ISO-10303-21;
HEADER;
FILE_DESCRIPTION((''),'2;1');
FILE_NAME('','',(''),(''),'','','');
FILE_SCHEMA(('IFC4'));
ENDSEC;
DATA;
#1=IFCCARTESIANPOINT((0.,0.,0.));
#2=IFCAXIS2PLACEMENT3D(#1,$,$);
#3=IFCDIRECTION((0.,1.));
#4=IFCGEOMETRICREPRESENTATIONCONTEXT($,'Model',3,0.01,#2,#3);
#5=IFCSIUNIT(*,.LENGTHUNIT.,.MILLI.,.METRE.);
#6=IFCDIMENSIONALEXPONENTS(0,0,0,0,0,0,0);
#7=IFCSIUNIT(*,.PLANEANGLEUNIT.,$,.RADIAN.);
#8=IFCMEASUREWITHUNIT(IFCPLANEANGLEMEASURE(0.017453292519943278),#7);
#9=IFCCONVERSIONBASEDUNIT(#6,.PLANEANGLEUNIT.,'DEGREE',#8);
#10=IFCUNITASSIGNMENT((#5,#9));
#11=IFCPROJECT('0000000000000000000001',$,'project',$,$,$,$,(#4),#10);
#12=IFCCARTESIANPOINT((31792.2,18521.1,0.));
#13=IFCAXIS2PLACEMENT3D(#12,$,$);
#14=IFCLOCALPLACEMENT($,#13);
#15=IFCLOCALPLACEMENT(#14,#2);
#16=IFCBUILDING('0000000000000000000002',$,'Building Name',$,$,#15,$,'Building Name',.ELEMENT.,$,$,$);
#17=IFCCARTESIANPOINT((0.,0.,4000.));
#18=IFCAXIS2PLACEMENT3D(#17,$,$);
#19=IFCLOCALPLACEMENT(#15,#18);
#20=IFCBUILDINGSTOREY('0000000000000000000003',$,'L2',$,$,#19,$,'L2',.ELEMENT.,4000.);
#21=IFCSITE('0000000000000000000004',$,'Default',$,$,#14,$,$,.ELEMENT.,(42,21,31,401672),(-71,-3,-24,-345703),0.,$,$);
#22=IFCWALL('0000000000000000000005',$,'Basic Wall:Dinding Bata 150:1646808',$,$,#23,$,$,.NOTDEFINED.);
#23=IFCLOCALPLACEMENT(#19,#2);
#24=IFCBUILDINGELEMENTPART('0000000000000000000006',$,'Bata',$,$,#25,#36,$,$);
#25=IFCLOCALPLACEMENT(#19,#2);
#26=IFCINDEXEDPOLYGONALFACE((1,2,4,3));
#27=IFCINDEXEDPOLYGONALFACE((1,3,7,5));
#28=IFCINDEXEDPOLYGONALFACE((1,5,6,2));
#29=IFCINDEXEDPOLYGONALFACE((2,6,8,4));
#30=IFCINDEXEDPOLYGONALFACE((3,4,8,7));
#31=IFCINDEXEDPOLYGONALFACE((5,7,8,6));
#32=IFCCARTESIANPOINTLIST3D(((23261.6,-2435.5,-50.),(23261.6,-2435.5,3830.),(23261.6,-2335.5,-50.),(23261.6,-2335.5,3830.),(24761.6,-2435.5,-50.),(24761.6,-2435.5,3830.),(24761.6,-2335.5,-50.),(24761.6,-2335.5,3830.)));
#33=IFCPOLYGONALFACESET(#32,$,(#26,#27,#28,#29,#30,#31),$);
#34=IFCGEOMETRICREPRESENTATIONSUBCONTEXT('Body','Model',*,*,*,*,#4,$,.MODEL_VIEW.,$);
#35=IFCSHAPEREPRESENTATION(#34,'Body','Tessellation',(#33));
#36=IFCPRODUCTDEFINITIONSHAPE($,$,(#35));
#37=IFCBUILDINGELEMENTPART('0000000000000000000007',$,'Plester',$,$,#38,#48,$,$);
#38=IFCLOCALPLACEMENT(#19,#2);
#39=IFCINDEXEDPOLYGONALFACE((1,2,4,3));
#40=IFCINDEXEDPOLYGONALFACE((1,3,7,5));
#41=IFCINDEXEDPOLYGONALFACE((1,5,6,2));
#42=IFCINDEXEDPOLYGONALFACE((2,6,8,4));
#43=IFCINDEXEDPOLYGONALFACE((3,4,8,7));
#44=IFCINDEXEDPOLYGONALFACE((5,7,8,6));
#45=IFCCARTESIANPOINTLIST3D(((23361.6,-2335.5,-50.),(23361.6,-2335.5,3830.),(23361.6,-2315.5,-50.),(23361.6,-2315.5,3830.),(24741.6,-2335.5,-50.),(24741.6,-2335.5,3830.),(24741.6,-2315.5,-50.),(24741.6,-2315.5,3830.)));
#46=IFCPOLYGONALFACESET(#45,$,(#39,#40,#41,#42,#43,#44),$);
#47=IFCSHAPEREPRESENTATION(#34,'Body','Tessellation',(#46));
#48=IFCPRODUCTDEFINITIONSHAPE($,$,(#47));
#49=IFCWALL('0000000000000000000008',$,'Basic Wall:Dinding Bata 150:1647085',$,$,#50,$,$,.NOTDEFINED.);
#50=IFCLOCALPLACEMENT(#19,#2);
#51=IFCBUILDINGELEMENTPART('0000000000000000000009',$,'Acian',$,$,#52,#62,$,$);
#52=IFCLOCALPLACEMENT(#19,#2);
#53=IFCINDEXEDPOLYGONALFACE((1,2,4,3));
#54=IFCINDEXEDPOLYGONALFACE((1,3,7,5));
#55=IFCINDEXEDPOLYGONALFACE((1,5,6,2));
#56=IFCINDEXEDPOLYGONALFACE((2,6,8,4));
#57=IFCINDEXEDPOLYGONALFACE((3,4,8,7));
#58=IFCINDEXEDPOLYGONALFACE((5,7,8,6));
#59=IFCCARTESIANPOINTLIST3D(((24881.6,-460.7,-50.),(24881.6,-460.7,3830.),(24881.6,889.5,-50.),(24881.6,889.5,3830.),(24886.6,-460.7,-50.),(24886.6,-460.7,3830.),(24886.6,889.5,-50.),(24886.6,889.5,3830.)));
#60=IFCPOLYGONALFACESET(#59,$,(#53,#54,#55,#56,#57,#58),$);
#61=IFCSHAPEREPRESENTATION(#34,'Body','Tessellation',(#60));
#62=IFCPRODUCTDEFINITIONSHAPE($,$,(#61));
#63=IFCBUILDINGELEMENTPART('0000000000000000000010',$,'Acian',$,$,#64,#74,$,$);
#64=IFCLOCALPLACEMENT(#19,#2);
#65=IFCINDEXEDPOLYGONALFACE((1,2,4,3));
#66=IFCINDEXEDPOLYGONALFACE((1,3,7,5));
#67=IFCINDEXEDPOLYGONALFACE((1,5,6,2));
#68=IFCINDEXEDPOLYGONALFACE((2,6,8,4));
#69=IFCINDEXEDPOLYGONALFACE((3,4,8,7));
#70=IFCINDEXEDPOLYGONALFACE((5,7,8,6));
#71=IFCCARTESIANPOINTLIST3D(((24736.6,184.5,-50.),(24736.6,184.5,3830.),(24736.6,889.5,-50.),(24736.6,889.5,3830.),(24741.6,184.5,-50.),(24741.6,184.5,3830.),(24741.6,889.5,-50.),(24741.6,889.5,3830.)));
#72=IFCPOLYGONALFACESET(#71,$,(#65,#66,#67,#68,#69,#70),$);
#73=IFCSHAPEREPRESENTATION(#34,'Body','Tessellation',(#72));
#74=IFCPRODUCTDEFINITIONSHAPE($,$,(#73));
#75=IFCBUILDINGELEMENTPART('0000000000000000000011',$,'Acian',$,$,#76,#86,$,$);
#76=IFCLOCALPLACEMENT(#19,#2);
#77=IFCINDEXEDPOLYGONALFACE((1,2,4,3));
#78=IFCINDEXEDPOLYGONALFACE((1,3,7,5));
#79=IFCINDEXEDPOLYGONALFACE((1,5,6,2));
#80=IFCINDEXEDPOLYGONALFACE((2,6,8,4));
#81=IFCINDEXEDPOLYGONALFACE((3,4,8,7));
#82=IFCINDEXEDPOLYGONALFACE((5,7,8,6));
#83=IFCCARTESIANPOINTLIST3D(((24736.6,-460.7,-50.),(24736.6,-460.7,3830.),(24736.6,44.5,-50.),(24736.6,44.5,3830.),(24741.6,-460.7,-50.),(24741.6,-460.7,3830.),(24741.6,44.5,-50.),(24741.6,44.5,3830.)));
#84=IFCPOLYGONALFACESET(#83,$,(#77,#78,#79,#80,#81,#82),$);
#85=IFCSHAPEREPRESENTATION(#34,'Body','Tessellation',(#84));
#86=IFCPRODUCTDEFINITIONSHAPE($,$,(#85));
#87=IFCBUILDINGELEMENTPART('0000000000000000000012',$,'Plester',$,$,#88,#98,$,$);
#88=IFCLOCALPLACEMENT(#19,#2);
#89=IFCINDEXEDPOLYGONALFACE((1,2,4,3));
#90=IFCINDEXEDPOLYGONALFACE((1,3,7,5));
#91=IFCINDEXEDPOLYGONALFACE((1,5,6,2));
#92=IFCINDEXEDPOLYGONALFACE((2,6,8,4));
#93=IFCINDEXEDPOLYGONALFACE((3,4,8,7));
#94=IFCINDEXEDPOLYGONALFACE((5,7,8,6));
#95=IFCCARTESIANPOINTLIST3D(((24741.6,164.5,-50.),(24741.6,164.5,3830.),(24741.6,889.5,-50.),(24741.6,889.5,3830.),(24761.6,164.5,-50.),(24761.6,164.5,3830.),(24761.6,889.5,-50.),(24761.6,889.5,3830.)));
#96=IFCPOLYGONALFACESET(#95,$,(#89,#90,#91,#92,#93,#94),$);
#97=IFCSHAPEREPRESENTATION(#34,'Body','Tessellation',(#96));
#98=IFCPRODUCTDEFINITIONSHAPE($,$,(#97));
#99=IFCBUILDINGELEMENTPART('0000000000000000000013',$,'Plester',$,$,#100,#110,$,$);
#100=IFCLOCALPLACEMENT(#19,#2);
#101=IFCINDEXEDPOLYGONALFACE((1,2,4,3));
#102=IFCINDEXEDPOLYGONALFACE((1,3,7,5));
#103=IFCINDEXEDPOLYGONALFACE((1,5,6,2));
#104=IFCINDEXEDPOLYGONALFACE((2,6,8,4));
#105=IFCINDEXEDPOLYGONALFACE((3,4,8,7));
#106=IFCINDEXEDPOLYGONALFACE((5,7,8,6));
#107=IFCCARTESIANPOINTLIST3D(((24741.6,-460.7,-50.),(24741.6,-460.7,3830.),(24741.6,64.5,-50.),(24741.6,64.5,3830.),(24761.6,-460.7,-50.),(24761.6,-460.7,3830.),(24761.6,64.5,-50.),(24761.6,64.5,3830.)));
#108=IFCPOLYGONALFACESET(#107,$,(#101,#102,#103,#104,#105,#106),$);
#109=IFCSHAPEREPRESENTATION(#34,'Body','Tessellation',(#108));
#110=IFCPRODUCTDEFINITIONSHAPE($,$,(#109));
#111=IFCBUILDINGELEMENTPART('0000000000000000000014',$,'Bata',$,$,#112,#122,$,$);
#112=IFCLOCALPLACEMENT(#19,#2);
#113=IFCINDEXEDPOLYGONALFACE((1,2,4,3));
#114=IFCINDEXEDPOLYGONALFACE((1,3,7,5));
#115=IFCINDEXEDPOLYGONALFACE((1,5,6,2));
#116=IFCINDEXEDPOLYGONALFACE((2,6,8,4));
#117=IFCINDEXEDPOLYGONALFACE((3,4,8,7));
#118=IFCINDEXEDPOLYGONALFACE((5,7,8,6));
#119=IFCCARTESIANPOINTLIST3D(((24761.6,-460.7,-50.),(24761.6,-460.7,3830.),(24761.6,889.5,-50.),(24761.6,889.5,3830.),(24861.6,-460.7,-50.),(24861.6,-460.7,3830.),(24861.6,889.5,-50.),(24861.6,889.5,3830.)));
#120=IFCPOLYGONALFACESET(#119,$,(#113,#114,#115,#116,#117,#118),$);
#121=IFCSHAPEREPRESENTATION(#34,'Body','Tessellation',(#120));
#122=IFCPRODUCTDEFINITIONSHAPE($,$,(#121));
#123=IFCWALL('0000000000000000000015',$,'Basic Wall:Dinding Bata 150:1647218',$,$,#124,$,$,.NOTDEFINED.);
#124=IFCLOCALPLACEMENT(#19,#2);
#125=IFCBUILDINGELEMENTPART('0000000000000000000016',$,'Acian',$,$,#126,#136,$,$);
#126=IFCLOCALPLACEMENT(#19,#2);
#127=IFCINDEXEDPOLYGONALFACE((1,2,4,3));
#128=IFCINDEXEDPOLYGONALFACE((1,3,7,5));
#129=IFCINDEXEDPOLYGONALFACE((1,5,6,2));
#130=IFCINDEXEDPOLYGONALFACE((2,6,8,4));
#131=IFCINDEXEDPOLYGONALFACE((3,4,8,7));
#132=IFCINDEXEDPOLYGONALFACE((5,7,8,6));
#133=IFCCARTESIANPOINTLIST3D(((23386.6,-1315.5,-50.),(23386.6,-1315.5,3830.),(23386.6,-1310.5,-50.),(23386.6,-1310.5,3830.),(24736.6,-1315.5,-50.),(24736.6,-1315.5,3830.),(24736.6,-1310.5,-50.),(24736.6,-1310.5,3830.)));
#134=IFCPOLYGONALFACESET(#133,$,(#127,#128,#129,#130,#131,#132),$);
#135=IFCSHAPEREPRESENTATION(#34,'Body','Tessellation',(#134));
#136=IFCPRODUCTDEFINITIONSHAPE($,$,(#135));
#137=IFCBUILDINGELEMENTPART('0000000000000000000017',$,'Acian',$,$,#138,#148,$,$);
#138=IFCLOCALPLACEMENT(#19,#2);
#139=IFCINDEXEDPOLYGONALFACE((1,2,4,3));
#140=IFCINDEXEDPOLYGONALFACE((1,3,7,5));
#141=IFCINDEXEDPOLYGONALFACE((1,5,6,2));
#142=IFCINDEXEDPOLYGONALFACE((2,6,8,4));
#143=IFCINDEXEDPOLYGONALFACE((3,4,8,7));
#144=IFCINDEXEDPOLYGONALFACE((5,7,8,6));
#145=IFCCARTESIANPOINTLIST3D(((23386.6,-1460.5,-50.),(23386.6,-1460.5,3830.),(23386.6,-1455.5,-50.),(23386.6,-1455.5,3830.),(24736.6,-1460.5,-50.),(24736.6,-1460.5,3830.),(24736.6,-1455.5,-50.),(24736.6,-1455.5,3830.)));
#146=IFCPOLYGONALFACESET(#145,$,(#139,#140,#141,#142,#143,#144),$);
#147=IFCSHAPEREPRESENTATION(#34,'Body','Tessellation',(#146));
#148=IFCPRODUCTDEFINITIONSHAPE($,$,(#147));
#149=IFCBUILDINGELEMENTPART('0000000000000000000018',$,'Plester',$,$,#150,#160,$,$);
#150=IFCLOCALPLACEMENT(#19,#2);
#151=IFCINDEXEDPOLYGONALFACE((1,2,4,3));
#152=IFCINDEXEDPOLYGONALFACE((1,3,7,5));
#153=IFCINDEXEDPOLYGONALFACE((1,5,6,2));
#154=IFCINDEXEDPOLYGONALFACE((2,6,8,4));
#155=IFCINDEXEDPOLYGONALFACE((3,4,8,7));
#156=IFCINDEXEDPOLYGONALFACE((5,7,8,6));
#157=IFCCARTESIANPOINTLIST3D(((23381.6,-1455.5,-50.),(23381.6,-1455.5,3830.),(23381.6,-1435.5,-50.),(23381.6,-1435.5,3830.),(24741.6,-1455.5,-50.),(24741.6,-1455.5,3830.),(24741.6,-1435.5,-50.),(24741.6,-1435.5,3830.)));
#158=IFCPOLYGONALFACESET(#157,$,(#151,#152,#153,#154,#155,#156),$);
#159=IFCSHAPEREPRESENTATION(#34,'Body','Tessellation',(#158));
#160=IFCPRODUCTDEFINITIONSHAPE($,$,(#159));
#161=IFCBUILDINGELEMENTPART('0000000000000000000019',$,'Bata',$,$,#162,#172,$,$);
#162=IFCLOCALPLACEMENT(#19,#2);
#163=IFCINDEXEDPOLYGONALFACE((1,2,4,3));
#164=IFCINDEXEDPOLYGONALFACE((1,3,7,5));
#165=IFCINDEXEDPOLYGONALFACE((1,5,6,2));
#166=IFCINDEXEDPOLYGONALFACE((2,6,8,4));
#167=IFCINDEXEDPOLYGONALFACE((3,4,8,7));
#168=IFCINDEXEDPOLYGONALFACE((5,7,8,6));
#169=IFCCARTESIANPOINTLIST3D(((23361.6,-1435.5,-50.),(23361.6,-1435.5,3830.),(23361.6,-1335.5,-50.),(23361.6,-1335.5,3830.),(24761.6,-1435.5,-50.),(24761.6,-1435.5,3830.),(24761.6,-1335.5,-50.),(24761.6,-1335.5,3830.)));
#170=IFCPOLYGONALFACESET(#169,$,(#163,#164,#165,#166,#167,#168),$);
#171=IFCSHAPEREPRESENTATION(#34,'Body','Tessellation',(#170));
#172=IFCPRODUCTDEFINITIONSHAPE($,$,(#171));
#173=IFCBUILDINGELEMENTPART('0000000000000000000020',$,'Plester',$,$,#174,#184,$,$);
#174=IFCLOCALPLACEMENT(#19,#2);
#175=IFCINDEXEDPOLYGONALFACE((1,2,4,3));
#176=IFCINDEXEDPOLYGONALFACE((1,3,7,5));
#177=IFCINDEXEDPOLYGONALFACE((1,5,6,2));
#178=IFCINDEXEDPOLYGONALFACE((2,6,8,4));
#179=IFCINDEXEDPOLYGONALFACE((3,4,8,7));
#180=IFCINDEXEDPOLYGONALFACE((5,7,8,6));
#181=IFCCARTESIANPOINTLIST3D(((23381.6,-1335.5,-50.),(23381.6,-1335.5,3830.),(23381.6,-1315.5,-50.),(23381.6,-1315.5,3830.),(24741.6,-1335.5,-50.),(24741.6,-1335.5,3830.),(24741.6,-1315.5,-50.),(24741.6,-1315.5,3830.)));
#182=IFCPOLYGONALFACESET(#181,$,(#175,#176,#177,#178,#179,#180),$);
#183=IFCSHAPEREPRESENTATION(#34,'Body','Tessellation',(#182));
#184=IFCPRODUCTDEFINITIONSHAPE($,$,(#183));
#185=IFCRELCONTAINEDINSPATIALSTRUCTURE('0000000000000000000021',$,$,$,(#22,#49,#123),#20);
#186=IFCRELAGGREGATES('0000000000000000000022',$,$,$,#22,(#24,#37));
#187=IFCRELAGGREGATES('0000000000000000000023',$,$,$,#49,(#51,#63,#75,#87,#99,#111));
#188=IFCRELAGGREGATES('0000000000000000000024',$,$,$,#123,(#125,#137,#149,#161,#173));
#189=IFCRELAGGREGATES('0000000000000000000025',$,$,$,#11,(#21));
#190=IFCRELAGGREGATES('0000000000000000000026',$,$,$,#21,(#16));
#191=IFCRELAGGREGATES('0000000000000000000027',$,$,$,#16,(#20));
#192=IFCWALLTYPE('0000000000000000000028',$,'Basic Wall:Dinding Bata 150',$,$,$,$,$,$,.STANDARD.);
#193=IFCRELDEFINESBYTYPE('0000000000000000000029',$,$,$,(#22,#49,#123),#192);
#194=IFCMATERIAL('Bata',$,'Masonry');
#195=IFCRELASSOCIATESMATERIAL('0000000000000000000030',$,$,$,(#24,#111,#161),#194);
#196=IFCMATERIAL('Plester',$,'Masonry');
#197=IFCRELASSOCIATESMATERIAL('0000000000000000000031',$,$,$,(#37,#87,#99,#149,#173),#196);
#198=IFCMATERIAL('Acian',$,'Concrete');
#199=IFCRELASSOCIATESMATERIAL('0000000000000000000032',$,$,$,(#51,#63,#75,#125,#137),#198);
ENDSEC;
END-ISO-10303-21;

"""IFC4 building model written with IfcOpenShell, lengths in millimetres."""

from ifc_helpers import new_model, entity, si_unit, converted_unit, direction, frame, origin, place, context, subcontext, project, spatial, indexed_curve, outline, extrude, material, type_object, element, aggregate, save


model = new_model("IFC4")

# Units and contexts
model_context = context("Model", 3, precision=0.01, world=origin(), true_north=direction((0.0, 1.0)))
body_context = subcontext(model_context, "Body", "Model", "MODEL_VIEW")
ifc_project = project(units=[si_unit("LENGTHUNIT", "METRE", prefix="MILLI"), converted_unit("PLANEANGLEUNIT", "DEGREE", entity("IfcPlaneAngleMeasure", 0.017453292519943278), si_unit("PLANEANGLEUNIT", "RADIAN"), dimensions=[0, 0, 0, 0, 0, 0, 0])], contexts=[model_context])

# Site, building, storey
site_placement = place(None, frame((31792.2, 18521.1, 0.0)))
site = spatial("IfcSite", under=ifc_project, at=site_placement, Name="Default", CompositionType="ELEMENT", RefLatitude=(42, 21, 31, 401672), RefLongitude=(-71, -3, -24, -345703), RefElevation=0.0)
building_placement = place(site_placement, origin())
building = spatial("IfcBuilding", under=site, at=building_placement, Name="Building Name", LongName="Building Name", CompositionType="ELEMENT")
storey_placement = place(building_placement, frame((0.0, 0.0, 4000.0)))
storey = spatial("IfcBuildingStorey", under=building, at=storey_placement, Name="L2", LongName="L2", CompositionType="ELEMENT", Elevation=4000.0)

# Walls, building element parts
wall_type = type_object("IfcWallType", Name="Basic Wall:Dinding Bata 150", PredefinedType="STANDARD")
ifc_material_1 = material(Name="Acian", Category="Concrete")
ifc_material_2 = material(Name="Plester", Category="Masonry")
ifc_material_3 = material(Name="Bata", Category="Masonry")
wall_1_placement = place(storey_placement, frame((24736.6, -2385.5, -50.0), z_axis=(0.0, 0.0, 1.0), x_axis=(-1.0, 0.0, 0.0)))
wall_1 = element("IfcWall", 1, at=wall_1_placement, inside=storey, type_object=wall_type, Name="Basic Wall:Dinding Bata 150:1646808", PredefinedType="NOTDEFINED")
building_element_part_1_placement = place(wall_1_placement, origin())
building_element_part_1 = element("IfcBuildingElementPart", 2, at=building_element_part_1_placement, material=ifc_material_3, Name="Bata", context=body_context, shape_type="SweptSolid", body=[
    extrude(outline(indexed_curve([(-50.0, -750.0), (50.0, -750.0), (50.0, 750.0), (-50.0, 750.0), (-50.0, -750.0)], self_intersect=False)), frame((725.0, 0.0, 0.0), z_axis=(0.0, 0.0, 1.0), x_axis=(0.0, 1.0, 0.0)), (0.0, 0.0, 1.0), 3880.0),
])
building_element_part_2_placement = place(wall_1_placement, origin())
building_element_part_2 = element("IfcBuildingElementPart", 3, at=building_element_part_2_placement, material=ifc_material_2, Name="Plester", context=body_context, shape_type="SweptSolid", body=[
    extrude(outline(indexed_curve([(-10.0, -690.0), (10.0, -690.0), (10.0, 690.0), (-10.0, 690.0), (-10.0, -690.0)], self_intersect=False)), frame((685.0, -60.0, 0.0), z_axis=(0.0, 0.0, 1.0), x_axis=(0.0, 1.0, 0.0)), (0.0, 0.0, 1.0), 3880.0),
])
aggregate(wall_1, [building_element_part_1, building_element_part_2])
wall_2_placement = place(storey_placement, frame((24811.6, -460.7, -50.0), z_axis=(0.0, 0.0, 1.0), x_axis=(0.0, 1.0, 0.0)))
wall_2 = element("IfcWall", 4, at=wall_2_placement, inside=storey, type_object=wall_type, Name="Basic Wall:Dinding Bata 150:1647085", PredefinedType="NOTDEFINED")
building_element_part_3_placement = place(wall_2_placement, origin())
building_element_part_3 = element("IfcBuildingElementPart", 5, at=building_element_part_3_placement, material=ifc_material_1, Name="Acian", context=body_context, shape_type="SweptSolid", body=[
    extrude(outline(indexed_curve([(-675.1, -2.5), (675.1, -2.5), (675.1, 2.5), (-675.1, 2.5), (-675.1, -2.5)], self_intersect=False)), frame((675.1, -72.5, 0.0), z_axis=(0.0, 0.0, 1.0), x_axis=(-1.0, 0.0, 0.0)), (0.0, 0.0, 1.0), 3880.0),
])
building_element_part_4_placement = place(wall_2_placement, origin())
building_element_part_4 = element("IfcBuildingElementPart", 6, at=building_element_part_4_placement, material=ifc_material_1, Name="Acian", context=body_context, shape_type="SweptSolid", body=[
    extrude(outline(indexed_curve([(-352.5, -2.5), (352.5, -2.5), (352.5, 2.5), (-352.5, 2.5), (-352.5, -2.5)], self_intersect=False)), frame((997.7, 72.5, 0.0), z_axis=(0.0, 0.0, 1.0), x_axis=(-1.0, 0.0, 0.0)), (0.0, 0.0, 1.0), 3880.0),
])
building_element_part_5_placement = place(wall_2_placement, origin())
building_element_part_5 = element("IfcBuildingElementPart", 7, at=building_element_part_5_placement, material=ifc_material_1, Name="Acian", context=body_context, shape_type="SweptSolid", body=[
    extrude(outline(indexed_curve([(-252.6, -2.5), (252.6, -2.5), (252.6, 2.5), (-252.6, 2.5), (-252.6, -2.5)], self_intersect=False)), frame((252.6, 72.5, 0.0), z_axis=(0.0, 0.0, 1.0), x_axis=(-1.0, 0.0, 0.0)), (0.0, 0.0, 1.0), 3880.0),
])
building_element_part_6_placement = place(wall_2_placement, origin())
building_element_part_6 = element("IfcBuildingElementPart", 8, at=building_element_part_6_placement, material=ifc_material_2, Name="Plester", context=body_context, shape_type="SweptSolid", body=[
    extrude(outline(indexed_curve([(-362.5, -10.0), (362.5, -10.0), (362.5, 10.0), (-362.5, 10.0), (-362.5, -10.0)], self_intersect=False)), frame((987.7, 60.0, 0.0), z_axis=(0.0, 0.0, 1.0), x_axis=(-1.0, 0.0, 0.0)), (0.0, 0.0, 1.0), 3880.0),
])
building_element_part_7_placement = place(wall_2_placement, origin())
building_element_part_7 = element("IfcBuildingElementPart", 9, at=building_element_part_7_placement, material=ifc_material_2, Name="Plester", context=body_context, shape_type="SweptSolid", body=[
    extrude(outline(indexed_curve([(-262.6, -10.0), (262.6, -10.0), (262.6, 10.0), (-262.6, 10.0), (-262.6, -10.0)], self_intersect=False)), frame((262.6, 60.0, 0.0), z_axis=(0.0, 0.0, 1.0), x_axis=(-1.0, 0.0, 0.0)), (0.0, 0.0, 1.0), 3880.0),
])
building_element_part_8_placement = place(wall_2_placement, origin())
building_element_part_8 = element("IfcBuildingElementPart", 10, at=building_element_part_8_placement, material=ifc_material_3, Name="Bata", context=body_context, shape_type="SweptSolid", body=[
    extrude(outline(indexed_curve([(-675.1, -50.0), (675.1, -50.0), (675.1, 50.0), (-675.1, 50.0), (-675.1, -50.0)], self_intersect=False)), frame((675.1, 0.0, 0.0), z_axis=(0.0, 0.0, 1.0), x_axis=(-1.0, 0.0, 0.0)), (0.0, 0.0, 1.0), 3880.0),
])
aggregate(wall_2, [building_element_part_3, building_element_part_4, building_element_part_5, building_element_part_6, building_element_part_7, building_element_part_8])
wall_3_placement = place(storey_placement, frame((24736.6, -1385.5, -50.0), z_axis=(0.0, 0.0, 1.0), x_axis=(-1.0, 0.0, 0.0)))
wall_3 = element("IfcWall", 11, at=wall_3_placement, inside=storey, type_object=wall_type, Name="Basic Wall:Dinding Bata 150:1647218", PredefinedType="NOTDEFINED")
building_element_part_9_placement = place(wall_3_placement, origin())
building_element_part_9 = element("IfcBuildingElementPart", 12, at=building_element_part_9_placement, material=ifc_material_1, Name="Acian", context=body_context, shape_type="SweptSolid", body=[
    extrude(outline(indexed_curve([(-2.5, -675.0), (2.5, -675.0), (2.5, 675.0), (-2.5, 675.0), (-2.5, -675.0)], self_intersect=False)), frame((675.0, -72.5, 0.0), z_axis=(0.0, 0.0, 1.0), x_axis=(0.0, 1.0, 0.0)), (0.0, 0.0, 1.0), 3880.0),
])
building_element_part_10_placement = place(wall_3_placement, origin())
building_element_part_10 = element("IfcBuildingElementPart", 13, at=building_element_part_10_placement, material=ifc_material_1, Name="Acian", context=body_context, shape_type="SweptSolid", body=[
    extrude(outline(indexed_curve([(-2.5, -675.0), (2.5, -675.0), (2.5, 675.0), (-2.5, 675.0), (-2.5, -675.0)], self_intersect=False)), frame((675.0, 72.5, 0.0), z_axis=(0.0, 0.0, 1.0), x_axis=(0.0, 1.0, 0.0)), (0.0, 0.0, 1.0), 3880.0),
])
building_element_part_11_placement = place(wall_3_placement, origin())
building_element_part_11 = element("IfcBuildingElementPart", 14, at=building_element_part_11_placement, material=ifc_material_2, Name="Plester", context=body_context, shape_type="SweptSolid", body=[
    extrude(outline(indexed_curve([(-10.0, -680.0), (10.0, -680.0), (10.0, 680.0), (-10.0, 680.0), (-10.0, -680.0)], self_intersect=False)), frame((675.0, 60.0, 0.0), z_axis=(0.0, 0.0, 1.0), x_axis=(0.0, 1.0, 0.0)), (0.0, 0.0, 1.0), 3880.0),
])
building_element_part_12_placement = place(wall_3_placement, origin())
building_element_part_12 = element("IfcBuildingElementPart", 15, at=building_element_part_12_placement, material=ifc_material_3, Name="Bata", context=body_context, shape_type="SweptSolid", body=[
    extrude(outline(indexed_curve([(-50.0, -700.0), (50.0, -700.0), (50.0, 700.0), (-50.0, 700.0), (-50.0, -700.0)], self_intersect=False)), frame((675.0, 0.0, 0.0), z_axis=(0.0, 0.0, 1.0), x_axis=(0.0, 1.0, 0.0)), (0.0, 0.0, 1.0), 3880.0),
])
building_element_part_13_placement = place(wall_3_placement, origin())
building_element_part_13 = element("IfcBuildingElementPart", 16, at=building_element_part_13_placement, material=ifc_material_2, Name="Plester", context=body_context, shape_type="SweptSolid", body=[
    extrude(outline(indexed_curve([(-10.0, -680.0), (10.0, -680.0), (10.0, 680.0), (-10.0, 680.0), (-10.0, -680.0)], self_intersect=False)), frame((675.0, -60.0, 0.0), z_axis=(0.0, 0.0, 1.0), x_axis=(0.0, 1.0, 0.0)), (0.0, 0.0, 1.0), 3880.0),
])
aggregate(wall_3, [building_element_part_9, building_element_part_10, building_element_part_11, building_element_part_12, building_element_part_13])

save(model, "model.ifc")
